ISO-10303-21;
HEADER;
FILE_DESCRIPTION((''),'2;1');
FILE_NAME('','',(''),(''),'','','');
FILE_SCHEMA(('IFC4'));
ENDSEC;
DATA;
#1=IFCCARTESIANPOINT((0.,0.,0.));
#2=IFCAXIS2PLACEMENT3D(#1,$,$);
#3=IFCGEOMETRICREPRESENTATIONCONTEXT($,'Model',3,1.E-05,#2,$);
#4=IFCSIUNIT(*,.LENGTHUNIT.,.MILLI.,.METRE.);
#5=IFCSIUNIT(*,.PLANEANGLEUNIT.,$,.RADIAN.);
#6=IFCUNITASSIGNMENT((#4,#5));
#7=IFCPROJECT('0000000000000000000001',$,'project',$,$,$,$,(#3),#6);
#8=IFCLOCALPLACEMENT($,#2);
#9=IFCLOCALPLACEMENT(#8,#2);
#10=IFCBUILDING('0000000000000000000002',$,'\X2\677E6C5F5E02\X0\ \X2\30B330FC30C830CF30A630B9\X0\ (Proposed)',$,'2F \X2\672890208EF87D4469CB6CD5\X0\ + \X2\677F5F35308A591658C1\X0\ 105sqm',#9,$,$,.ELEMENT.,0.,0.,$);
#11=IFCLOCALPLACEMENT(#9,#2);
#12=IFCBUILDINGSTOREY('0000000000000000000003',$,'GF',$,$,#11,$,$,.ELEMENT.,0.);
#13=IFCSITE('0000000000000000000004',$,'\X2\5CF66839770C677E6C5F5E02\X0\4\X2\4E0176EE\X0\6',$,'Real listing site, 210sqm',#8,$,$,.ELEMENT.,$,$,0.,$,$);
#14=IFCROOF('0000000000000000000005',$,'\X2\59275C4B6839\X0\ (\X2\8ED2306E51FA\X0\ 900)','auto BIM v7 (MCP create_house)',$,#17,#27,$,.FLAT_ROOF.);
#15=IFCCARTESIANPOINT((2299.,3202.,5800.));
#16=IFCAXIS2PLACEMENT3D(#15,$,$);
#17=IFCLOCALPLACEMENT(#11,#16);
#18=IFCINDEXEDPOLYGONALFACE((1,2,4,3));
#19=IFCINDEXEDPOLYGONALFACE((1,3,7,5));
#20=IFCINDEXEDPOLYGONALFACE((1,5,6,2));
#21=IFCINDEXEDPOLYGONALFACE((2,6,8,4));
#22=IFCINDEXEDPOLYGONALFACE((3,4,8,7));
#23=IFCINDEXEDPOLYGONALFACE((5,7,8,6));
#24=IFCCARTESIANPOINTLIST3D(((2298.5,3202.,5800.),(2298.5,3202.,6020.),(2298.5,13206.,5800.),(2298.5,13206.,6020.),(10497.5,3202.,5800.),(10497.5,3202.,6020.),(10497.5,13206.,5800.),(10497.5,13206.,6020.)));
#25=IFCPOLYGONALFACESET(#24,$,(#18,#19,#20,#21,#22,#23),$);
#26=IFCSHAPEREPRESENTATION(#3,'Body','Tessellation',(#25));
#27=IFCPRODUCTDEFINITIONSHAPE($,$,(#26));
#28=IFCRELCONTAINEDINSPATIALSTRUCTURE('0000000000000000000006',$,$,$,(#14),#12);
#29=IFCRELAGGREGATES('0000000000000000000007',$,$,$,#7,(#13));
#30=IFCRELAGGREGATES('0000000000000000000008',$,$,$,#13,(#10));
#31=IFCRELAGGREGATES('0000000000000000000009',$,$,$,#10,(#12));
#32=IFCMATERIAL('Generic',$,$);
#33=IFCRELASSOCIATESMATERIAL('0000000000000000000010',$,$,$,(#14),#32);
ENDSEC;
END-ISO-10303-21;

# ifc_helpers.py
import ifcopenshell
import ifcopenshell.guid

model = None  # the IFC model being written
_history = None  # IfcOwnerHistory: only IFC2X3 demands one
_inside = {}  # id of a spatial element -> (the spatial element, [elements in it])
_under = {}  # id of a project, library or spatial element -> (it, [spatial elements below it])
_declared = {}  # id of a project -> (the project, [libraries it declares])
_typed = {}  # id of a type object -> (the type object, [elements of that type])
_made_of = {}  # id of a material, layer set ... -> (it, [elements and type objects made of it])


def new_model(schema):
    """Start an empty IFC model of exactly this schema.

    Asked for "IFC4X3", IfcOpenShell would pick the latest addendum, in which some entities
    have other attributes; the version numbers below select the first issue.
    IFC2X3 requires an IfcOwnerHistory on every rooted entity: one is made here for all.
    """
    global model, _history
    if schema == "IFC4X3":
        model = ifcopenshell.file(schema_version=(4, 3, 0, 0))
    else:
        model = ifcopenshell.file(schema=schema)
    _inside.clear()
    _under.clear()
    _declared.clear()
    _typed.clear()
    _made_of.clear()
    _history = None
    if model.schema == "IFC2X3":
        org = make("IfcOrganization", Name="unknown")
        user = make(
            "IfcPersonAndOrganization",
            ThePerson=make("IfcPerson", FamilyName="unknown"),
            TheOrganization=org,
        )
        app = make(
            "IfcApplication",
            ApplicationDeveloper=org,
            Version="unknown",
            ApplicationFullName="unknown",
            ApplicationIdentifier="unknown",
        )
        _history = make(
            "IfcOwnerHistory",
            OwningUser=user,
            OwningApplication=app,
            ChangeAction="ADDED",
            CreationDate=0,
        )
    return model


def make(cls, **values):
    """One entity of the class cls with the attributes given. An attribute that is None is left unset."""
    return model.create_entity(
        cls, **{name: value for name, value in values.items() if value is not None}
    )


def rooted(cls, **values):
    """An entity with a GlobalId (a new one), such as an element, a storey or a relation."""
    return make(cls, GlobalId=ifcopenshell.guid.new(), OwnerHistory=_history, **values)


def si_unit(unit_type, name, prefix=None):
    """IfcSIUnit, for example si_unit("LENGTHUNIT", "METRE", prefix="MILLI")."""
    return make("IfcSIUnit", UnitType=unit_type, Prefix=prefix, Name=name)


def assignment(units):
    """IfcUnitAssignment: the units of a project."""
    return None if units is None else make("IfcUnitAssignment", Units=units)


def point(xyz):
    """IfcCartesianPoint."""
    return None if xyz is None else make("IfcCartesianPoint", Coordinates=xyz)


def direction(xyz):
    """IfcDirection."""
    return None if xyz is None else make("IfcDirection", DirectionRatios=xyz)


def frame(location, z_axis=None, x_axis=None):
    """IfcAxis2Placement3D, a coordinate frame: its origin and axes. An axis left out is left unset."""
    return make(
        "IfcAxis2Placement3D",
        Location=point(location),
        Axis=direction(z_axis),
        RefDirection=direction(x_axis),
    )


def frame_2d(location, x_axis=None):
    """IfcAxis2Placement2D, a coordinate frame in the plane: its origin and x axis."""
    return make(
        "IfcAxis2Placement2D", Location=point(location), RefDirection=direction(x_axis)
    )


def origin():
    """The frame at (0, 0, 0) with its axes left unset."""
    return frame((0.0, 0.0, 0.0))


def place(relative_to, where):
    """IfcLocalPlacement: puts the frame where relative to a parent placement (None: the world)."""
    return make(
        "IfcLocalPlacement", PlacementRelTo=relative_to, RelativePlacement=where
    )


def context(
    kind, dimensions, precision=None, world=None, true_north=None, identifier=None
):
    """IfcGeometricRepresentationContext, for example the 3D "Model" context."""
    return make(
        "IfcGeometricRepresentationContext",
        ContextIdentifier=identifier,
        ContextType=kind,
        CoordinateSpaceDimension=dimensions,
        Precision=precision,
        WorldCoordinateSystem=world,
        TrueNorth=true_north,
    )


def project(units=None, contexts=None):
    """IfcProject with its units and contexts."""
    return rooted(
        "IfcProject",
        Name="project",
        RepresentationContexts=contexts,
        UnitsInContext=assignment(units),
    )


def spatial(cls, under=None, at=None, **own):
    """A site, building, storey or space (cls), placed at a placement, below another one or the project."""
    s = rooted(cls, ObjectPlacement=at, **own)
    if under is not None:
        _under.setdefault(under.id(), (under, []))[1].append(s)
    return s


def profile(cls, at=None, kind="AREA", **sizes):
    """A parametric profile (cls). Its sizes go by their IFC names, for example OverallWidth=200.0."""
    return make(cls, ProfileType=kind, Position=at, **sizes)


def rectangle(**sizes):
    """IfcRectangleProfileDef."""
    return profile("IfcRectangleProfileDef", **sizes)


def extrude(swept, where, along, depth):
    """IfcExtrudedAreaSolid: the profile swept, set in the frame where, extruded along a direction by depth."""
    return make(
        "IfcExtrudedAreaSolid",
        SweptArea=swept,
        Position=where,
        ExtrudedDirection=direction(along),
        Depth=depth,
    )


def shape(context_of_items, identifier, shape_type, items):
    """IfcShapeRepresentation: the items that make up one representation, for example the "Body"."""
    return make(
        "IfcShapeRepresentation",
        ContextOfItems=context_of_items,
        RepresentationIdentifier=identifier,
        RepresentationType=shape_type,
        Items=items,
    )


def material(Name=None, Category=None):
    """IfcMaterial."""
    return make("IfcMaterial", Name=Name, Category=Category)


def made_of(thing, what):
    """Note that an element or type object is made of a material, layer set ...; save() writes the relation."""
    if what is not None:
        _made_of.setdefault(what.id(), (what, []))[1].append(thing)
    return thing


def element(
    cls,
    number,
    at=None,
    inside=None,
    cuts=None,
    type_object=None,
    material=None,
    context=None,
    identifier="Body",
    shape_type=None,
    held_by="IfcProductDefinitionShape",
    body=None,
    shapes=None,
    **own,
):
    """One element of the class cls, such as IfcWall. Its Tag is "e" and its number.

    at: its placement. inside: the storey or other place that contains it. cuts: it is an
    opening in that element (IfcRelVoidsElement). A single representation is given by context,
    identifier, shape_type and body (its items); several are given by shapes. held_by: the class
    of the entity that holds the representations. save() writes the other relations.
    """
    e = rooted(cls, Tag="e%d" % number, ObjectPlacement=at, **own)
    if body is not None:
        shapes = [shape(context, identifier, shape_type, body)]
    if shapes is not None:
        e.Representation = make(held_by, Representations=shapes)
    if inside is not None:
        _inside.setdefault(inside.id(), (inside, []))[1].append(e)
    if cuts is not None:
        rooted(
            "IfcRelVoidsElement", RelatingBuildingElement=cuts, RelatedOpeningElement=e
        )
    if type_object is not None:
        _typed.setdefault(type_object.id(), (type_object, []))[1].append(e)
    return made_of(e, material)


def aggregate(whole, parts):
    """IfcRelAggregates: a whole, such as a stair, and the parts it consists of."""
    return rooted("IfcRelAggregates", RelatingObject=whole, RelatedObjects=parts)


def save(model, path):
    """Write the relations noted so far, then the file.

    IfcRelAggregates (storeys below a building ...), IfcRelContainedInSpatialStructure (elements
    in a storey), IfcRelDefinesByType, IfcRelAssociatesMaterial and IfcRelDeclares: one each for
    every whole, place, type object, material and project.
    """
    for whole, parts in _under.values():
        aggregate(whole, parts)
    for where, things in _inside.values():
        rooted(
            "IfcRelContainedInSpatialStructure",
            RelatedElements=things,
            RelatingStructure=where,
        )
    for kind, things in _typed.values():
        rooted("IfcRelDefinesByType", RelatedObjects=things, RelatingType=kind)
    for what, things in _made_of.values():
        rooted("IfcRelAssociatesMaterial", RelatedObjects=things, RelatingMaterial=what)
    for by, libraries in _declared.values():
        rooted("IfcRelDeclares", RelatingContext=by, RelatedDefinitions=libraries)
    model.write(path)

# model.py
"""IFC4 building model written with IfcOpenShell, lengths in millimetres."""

from ifc_helpers import new_model, si_unit, frame, frame_2d, origin, place, context, project, spatial, rectangle, extrude, material, element, save


model = new_model("IFC4")

# Units and contexts
model_context = context("Model", 3, precision=1e-05, world=origin())
ifc_project = project(units=[si_unit("LENGTHUNIT", "METRE", prefix="MILLI"), si_unit("PLANEANGLEUNIT", "RADIAN")], contexts=[model_context])

# Site, building, storey
site_placement = place(None, origin())
site = spatial("IfcSite", under=ifc_project, at=site_placement, Name="島根県松江市4丁目6", ObjectType="Real listing site, 210sqm", CompositionType="ELEMENT", RefElevation=0.0)
building_placement = place(site_placement, origin())
building = spatial("IfcBuilding", under=site, at=building_placement, Name="松江市 コートハウス (Proposed)", ObjectType="2F 木造軸組構法 + 板張り外壁 105sqm", CompositionType="ELEMENT", ElevationOfRefHeight=0.0, ElevationOfTerrain=0.0)
storey_placement = place(building_placement, origin())
storey = spatial("IfcBuildingStorey", under=building, at=storey_placement, Name="GF", CompositionType="ELEMENT", Elevation=0.0)

# Shared definitions
ifc_material = material(Name="Generic")

# Roof
roof_placement = place(storey_placement, frame((2299.0, 3202.0, 5800.0)))
element("IfcRoof", 1, at=roof_placement, inside=storey, material=ifc_material, Name="大屋根 (軒の出 900)", Description="auto BIM v7 (MCP create_house)", PredefinedType="FLAT_ROOF", context=model_context, shape_type="SweptSolid", body=[
    extrude(rectangle(XDim=8199.0, YDim=10004.0, at=frame_2d((4099.0, 5002.0))), frame((2299.0, 3202.0, 5800.0)), (0.0, 0.0, 1.0), 220.0),
])

save(model, "model.ifc")
